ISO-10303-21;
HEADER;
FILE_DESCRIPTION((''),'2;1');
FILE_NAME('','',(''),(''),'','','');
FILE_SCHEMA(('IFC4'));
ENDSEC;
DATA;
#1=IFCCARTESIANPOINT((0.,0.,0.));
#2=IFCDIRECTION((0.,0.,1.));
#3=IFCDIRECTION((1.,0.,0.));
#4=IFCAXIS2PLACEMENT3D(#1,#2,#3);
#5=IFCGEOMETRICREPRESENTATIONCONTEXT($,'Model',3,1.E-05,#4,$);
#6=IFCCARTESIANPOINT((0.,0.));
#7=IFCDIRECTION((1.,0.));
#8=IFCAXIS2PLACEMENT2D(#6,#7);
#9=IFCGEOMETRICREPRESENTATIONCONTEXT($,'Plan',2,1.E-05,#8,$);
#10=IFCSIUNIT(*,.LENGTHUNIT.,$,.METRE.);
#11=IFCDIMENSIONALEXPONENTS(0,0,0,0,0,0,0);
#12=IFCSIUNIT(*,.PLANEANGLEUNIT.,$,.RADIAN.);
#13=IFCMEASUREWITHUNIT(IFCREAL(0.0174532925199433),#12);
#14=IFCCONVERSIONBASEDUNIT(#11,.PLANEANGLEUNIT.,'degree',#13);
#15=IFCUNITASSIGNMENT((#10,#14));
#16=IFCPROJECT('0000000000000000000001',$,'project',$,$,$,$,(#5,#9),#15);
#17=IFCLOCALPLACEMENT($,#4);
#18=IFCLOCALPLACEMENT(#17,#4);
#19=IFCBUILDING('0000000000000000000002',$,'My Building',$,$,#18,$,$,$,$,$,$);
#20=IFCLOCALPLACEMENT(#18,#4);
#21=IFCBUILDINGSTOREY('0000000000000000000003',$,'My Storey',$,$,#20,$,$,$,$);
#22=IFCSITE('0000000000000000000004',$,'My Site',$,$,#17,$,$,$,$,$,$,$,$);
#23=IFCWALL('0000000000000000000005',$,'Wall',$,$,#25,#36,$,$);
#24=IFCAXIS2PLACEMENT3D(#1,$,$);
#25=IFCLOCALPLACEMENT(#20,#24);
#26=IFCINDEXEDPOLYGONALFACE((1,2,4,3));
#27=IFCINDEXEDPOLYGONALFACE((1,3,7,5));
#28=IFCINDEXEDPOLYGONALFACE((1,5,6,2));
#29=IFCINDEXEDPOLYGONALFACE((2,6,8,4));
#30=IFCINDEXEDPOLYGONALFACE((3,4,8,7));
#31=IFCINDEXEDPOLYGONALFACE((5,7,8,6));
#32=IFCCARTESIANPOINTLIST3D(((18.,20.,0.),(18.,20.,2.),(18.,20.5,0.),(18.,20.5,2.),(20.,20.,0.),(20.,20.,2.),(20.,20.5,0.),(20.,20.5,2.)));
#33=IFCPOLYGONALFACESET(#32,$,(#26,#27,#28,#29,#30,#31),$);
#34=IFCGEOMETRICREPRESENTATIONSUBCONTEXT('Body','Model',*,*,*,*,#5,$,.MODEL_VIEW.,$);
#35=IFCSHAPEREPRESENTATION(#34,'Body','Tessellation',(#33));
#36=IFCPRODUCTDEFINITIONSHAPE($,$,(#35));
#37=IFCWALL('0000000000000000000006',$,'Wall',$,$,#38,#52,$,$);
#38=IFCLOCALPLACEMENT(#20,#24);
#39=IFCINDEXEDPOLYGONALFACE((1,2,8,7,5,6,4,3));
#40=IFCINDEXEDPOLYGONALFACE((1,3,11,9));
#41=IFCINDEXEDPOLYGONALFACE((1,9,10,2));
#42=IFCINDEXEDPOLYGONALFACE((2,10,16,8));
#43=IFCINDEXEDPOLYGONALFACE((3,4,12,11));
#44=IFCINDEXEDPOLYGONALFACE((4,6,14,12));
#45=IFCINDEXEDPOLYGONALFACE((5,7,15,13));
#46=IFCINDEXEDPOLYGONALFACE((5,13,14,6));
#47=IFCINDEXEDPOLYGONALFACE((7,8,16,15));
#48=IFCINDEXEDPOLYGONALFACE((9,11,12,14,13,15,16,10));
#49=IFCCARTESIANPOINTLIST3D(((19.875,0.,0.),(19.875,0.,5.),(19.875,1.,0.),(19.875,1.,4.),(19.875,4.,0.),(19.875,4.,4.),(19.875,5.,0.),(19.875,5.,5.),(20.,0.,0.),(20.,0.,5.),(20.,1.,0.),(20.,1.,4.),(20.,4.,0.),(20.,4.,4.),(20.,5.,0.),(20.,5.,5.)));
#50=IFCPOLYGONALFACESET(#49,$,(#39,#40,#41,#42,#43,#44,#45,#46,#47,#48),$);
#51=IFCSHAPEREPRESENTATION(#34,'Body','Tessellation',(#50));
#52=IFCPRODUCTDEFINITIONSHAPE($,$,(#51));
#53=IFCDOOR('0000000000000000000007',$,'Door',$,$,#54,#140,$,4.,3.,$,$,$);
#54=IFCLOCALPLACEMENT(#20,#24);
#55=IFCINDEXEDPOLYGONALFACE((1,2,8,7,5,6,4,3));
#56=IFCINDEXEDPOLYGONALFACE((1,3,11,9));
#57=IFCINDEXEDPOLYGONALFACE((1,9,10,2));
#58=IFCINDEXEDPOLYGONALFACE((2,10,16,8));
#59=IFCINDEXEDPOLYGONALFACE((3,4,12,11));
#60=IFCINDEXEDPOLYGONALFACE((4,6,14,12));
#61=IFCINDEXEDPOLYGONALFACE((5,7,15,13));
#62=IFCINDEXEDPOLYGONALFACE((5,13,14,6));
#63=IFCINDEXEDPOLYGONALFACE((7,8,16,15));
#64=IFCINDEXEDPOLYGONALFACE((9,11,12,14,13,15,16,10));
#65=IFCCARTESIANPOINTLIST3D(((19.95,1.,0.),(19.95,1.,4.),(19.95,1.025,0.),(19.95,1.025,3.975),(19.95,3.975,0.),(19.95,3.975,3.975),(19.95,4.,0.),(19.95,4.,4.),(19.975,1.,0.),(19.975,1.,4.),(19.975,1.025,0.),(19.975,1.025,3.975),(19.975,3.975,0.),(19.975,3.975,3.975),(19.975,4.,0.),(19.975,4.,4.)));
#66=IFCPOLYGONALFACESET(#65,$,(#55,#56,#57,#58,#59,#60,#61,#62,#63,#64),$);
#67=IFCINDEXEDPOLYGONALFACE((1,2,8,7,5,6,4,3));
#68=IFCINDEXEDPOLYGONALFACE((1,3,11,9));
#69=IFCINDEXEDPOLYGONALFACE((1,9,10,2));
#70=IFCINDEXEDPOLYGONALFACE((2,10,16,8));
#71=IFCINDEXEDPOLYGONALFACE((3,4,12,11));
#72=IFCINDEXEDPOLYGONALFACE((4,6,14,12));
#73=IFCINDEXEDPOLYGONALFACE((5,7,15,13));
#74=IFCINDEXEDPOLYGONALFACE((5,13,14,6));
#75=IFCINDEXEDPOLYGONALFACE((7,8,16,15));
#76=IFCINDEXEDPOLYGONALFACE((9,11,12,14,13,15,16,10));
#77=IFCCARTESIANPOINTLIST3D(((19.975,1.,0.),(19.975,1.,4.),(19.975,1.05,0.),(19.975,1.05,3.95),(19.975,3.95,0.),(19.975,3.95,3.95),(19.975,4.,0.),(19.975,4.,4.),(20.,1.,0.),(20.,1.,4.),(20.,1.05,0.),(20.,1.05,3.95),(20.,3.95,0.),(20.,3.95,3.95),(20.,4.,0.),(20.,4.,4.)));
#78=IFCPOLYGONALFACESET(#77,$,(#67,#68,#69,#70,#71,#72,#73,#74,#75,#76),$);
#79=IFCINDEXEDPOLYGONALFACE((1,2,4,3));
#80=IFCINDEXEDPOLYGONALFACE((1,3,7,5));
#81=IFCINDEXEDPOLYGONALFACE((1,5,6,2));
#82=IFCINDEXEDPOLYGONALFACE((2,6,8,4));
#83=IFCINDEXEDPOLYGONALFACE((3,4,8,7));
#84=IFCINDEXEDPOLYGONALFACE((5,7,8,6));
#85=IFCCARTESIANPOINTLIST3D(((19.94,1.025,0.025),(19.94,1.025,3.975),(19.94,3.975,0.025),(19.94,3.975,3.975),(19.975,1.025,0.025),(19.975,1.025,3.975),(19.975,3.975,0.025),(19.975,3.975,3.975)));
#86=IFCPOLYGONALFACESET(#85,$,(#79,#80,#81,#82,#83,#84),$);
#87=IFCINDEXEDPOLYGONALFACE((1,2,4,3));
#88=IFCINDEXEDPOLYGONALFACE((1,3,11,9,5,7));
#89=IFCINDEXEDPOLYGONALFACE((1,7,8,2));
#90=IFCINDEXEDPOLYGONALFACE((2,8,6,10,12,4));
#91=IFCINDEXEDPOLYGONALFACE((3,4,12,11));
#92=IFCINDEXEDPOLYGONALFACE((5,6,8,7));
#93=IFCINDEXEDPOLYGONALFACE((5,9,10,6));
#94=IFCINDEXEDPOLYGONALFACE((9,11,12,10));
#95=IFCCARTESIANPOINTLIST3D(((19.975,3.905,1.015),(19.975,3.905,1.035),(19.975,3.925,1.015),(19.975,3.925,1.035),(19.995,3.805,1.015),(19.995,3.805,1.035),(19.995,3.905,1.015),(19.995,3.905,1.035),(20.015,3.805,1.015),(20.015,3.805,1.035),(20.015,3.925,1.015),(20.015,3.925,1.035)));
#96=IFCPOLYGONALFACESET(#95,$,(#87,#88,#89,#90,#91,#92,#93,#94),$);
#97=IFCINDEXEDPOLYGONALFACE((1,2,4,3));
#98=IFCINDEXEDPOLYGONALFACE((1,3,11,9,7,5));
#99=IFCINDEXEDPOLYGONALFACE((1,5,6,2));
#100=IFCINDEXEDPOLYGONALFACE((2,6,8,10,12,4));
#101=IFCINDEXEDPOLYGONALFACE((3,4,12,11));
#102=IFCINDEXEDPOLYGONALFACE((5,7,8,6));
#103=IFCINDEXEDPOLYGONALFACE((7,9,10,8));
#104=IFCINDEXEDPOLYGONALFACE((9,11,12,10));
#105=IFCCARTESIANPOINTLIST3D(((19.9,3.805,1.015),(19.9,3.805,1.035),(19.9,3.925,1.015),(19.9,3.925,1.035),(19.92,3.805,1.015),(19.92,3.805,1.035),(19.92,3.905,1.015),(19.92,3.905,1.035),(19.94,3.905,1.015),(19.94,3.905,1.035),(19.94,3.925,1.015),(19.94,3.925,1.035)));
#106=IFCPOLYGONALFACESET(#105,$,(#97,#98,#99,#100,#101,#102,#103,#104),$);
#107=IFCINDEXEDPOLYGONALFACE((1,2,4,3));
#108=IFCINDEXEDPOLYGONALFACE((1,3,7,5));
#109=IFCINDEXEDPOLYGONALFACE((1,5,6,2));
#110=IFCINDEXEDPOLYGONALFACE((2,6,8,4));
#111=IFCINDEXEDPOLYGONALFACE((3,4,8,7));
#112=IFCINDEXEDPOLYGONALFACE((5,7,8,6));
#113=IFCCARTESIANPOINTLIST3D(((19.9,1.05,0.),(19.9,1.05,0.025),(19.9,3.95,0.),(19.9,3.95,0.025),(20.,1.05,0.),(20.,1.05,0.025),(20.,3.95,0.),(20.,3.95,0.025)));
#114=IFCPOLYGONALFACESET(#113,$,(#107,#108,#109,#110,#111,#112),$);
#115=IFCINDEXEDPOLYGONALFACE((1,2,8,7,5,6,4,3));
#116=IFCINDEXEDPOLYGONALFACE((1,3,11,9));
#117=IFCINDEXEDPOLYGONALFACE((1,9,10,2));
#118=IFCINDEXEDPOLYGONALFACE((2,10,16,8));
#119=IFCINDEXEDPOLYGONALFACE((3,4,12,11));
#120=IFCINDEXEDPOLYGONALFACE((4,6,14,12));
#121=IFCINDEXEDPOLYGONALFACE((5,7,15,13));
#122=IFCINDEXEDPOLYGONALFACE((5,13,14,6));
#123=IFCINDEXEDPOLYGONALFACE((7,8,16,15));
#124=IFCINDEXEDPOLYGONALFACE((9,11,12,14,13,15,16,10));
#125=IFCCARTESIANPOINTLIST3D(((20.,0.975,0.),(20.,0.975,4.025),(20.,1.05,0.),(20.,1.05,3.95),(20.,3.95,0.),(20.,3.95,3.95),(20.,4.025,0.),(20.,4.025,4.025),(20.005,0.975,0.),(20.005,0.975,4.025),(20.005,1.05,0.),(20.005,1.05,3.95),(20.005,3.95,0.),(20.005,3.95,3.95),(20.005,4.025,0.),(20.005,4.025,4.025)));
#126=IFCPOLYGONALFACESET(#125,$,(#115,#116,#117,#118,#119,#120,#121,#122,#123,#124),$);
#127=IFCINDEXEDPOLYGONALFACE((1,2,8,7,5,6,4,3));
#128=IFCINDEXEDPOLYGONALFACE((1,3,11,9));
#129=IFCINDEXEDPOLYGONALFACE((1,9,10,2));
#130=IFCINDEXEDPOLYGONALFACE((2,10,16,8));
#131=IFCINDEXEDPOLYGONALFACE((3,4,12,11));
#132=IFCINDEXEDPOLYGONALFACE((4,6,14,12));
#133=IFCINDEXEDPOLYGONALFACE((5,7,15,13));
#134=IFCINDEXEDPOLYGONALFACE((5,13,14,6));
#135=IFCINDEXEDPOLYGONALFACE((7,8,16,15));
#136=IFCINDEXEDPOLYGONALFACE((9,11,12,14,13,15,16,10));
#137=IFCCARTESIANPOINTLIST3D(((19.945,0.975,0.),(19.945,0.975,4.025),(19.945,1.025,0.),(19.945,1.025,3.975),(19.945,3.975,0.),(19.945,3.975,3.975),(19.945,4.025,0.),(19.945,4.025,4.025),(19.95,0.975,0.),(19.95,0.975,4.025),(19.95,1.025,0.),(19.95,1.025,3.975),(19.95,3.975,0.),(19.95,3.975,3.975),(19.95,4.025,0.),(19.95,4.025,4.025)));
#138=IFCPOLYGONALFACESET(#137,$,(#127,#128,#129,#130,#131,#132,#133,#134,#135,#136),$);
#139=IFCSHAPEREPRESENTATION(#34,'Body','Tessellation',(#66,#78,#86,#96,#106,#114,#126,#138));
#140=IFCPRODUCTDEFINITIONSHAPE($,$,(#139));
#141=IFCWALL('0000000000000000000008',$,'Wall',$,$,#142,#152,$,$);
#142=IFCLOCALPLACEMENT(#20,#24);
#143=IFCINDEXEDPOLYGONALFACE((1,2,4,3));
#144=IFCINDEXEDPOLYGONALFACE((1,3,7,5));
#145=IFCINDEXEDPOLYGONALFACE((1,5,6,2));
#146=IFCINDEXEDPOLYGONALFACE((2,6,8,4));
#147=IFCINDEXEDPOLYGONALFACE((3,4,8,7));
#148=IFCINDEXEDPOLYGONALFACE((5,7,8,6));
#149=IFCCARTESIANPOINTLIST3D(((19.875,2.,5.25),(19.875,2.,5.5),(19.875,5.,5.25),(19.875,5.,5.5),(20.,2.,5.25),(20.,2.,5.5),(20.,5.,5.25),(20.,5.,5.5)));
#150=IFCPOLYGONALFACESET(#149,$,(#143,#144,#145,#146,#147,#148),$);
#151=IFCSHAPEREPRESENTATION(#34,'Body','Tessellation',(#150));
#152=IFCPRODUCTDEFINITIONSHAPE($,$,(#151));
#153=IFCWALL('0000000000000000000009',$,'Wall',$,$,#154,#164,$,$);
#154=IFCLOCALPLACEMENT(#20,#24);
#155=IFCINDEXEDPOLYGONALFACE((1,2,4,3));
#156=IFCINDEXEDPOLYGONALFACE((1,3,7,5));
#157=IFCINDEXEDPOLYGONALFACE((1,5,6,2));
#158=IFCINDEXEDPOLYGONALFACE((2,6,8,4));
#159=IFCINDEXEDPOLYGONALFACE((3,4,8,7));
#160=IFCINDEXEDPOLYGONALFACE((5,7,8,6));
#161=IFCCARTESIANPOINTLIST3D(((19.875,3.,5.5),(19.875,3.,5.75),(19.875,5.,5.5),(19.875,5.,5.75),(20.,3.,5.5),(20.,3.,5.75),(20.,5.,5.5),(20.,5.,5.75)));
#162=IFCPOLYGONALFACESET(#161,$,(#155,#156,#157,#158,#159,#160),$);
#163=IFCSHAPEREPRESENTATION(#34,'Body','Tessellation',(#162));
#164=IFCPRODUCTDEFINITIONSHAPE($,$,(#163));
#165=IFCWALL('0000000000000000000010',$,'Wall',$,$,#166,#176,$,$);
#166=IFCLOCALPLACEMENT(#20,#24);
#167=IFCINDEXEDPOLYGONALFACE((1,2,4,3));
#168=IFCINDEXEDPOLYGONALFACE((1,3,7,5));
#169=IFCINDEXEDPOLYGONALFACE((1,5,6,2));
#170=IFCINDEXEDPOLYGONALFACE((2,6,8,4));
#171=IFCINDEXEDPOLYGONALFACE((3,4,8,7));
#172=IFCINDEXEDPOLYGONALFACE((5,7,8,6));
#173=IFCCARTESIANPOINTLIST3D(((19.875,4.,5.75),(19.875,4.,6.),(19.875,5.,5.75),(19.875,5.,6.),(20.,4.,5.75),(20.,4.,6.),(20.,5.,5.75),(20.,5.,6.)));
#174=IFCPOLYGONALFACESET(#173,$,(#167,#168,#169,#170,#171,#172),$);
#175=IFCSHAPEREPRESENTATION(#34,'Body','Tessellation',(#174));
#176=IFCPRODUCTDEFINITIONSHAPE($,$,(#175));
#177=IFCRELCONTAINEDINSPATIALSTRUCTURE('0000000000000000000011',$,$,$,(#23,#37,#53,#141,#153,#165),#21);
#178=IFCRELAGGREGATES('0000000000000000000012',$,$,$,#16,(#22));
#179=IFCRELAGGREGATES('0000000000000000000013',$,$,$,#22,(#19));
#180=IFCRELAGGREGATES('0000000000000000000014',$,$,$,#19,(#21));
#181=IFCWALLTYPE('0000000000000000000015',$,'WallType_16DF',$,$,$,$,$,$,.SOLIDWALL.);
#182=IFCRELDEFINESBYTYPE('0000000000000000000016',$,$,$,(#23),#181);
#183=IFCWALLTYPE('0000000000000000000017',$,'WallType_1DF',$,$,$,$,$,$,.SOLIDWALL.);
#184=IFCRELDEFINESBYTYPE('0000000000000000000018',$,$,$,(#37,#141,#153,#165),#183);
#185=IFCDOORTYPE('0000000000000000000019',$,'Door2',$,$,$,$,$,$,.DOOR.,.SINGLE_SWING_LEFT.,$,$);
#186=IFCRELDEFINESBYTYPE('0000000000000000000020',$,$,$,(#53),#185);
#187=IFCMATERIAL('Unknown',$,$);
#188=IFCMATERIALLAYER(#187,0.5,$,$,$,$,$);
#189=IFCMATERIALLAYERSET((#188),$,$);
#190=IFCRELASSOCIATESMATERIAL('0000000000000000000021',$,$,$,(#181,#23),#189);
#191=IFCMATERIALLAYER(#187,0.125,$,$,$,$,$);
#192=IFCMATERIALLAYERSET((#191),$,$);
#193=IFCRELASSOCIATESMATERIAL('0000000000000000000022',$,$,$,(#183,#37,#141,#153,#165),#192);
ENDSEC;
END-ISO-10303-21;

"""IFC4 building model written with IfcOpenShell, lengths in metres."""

from ifc_helpers import new_model, entity, si_unit, converted_unit, frame, origin_with_axes, origin_2d_with_axis, place, context, subcontext, project, spatial, line, indexed_curve, outline, extrude, shape, source, transform, mapped, material, layer, layer_set, layer_usage, type_object, type_shapes, element, fill, save


model = new_model("IFC4")

# Units and contexts
model_context = context("Model", 3, precision=1e-05, world=origin_with_axes())
plan_context = context("Plan", 2, precision=1e-05, world=origin_2d_with_axis())
body_context_1 = subcontext(model_context, "Body", "Model", "MODEL_VIEW")
body_context_2 = subcontext(plan_context, "Body", "Plan", "PLAN_VIEW")
ifc_project = project(units=[si_unit("LENGTHUNIT", "METRE"), converted_unit("PLANEANGLEUNIT", "degree", entity("IfcReal", 0.0174532925199433), si_unit("PLANEANGLEUNIT", "RADIAN"), dimensions=[0, 0, 0, 0, 0, 0, 0])], contexts=[model_context, plan_context])

# Site, building, storey
site_placement = place(None, origin_with_axes())
site = spatial("IfcSite", under=ifc_project, at=site_placement, Name="My Site")
building_placement = place(site_placement, origin_with_axes())
building = spatial("IfcBuilding", under=site, at=building_placement, Name="My Building")
storey_placement = place(building_placement, origin_with_axes())
storey = spatial("IfcBuildingStorey", under=building, at=storey_placement, Name="My Storey")

# Wall
ifc_material = material(Name="Unknown")
ifc_layer_1 = layer(ifc_material, 0.5)
ifc_layer_set_1 = layer_set([ifc_layer_1])
ifc_layer_usage_1 = layer_usage(ifc_layer_set_1, "AXIS2", "POSITIVE", 0.0)
wall_type_1 = type_object("IfcWallType", Name="WallType_16DF", PredefinedType="SOLIDWALL", material=ifc_layer_set_1)
wall_1_placement = place(storey_placement, frame((18.0, 20.0, 0.0), z_axis=(0.0, 0.0, 1.0), x_axis=(1.0, 0.0, 0.0)))
element("IfcWall", 1, at=wall_1_placement, inside=storey, type_object=wall_type_1, material=ifc_layer_usage_1, Name="Wall", context=body_context_1, shape_type="SweptSolid", body=[
    extrude(outline(indexed_curve([(0.0, 0.0), (0.0, 0.5), (2.0, 0.5), (2.0, 0.0), (0.0, 0.0)], self_intersect=False)), origin_with_axes(), (0.0, 0.0, 1.0), 2.0),
])

# Wall, opening, door
ifc_layer_2 = layer(ifc_material, 0.125)
ifc_layer_set_2 = layer_set([ifc_layer_2])
ifc_layer_usage_2 = layer_usage(ifc_layer_set_2, "AXIS2", "POSITIVE", 0.0)
wall_type_2 = type_object("IfcWallType", Name="WallType_1DF", PredefinedType="SOLIDWALL", material=ifc_layer_set_2)
wall_2_placement = place(storey_placement, frame((20.0, 0.0, 0.0), z_axis=(0.0, 0.0, 1.0), x_axis=(0.0, 1.0, 0.0)))
wall_2 = element("IfcWall", 2, at=wall_2_placement, inside=storey, type_object=wall_type_2, material=ifc_layer_usage_2, Name="Wall", context=body_context_1, shape_type="SweptSolid", body=[
    extrude(outline(indexed_curve([(0.0, 0.0), (0.0, 0.125), (5.0, 0.125), (5.0, 0.0), (0.0, 0.0)], self_intersect=False)), origin_with_axes(), (0.0, 0.0, 1.0), 5.0),
])
shared_shape_1 = source(origin_with_axes(), body_context_1, "Body", "SweptSolid", [
    extrude(outline(indexed_curve([(0.0, 0.0), (3.0, 0.0), (3.0, 4.0), (0.0, 4.0)], segments=[line(1, 2, 3, 4, 1)])), frame((0.0, -0.1, 0.0), z_axis=(0.0, -1.0, 0.0), x_axis=(1.0, 0.0, 0.0)), (0.0, 0.0, -1.0), 0.45),
])
opening_1_placement = place(wall_2_placement, frame((1.0, 0.0, 0.0), z_axis=(0.0, 0.0, 1.0), x_axis=(1.0, 0.0, 0.0)))
opening_1 = element("IfcOpeningElement", 3, at=opening_1_placement, cuts=wall_2, PredefinedType="OPENING", context=body_context_1, shape_type="MappedRepresentation", body=[
    mapped(shared_shape_1, transform((0.0, 0.0, 0.0), x_axis=(1.0, 0.0, 0.0), y_axis=(0.0, 1.0, 0.0), z_axis=(0.0, 0.0, 1.0), scale=1.0)),
])
door_type_1 = type_object("IfcDoorType", Name="Door2", OperationType="SINGLE_SWING_LEFT", PredefinedType="DOOR")
shared_shape_2 = source(origin_with_axes(), body_context_1, "Body", "SweptSolid", [
    extrude(outline(indexed_curve([(0.0, 0.0), (0.0, 4.0), (3.0, 4.0), (3.0, 0.0), (2.975, 0.0), (2.975, 3.975), (0.025, 3.975), (0.025, 0.0)], segments=[line(1, 2, 3, 4, 5, 6, 7, 8, 1)])), frame((0.0, 0.025, 0.0), z_axis=(0.0, -1.0, 0.0), x_axis=(1.0, 0.0, 0.0)), (0.0, 0.0, -1.0), 0.025),
    extrude(outline(indexed_curve([(0.0, 0.0), (0.0, 4.0), (3.0, 4.0), (3.0, 0.0), (2.95, 0.0), (2.95, 3.95), (0.05, 3.95), (0.05, 0.0)], segments=[line(1, 2, 3, 4, 5, 6, 7, 8, 1)])), frame((0.0, 0.0, 0.0), z_axis=(0.0, -1.0, 0.0), x_axis=(1.0, 0.0, 0.0)), (0.0, 0.0, -1.0), 0.025),
    extrude(outline(indexed_curve([(0.0, 0.0), (2.95, 0.0), (2.95, 0.035), (0.0, 0.035)], segments=[line(1, 2, 3, 4, 1)])), frame((0.025, 0.025, 0.025), z_axis=(0.0, 0.0, 1.0), x_axis=(1.0, 0.0, 0.0)), (0.0, 0.0, 1.0), 3.95),
    extrude(outline(indexed_curve([(0.0, 0.0), (0.0, -0.04), (-0.12, -0.04), (-0.12, -0.02), (-0.02, -0.02), (-0.02, 0.0)], segments=[line(1, 2, 3, 4, 5, 6, 1)])), frame((2.925, 0.025, 1.015), z_axis=(0.0, 0.0, 1.0), x_axis=(1.0, 0.0, 0.0)), (0.0, 0.0, 1.0), 0.02),
    extrude(outline(indexed_curve([(0.0, 0.0), (0.0, 0.04), (-0.12, 0.04), (-0.12, 0.02), (-0.02, 0.02), (-0.02, 0.0)], segments=[line(1, 2, 3, 4, 5, 6, 1)])), frame((2.925, 0.06, 1.015), z_axis=(0.0, 0.0, 1.0), x_axis=(1.0, 0.0, 0.0)), (0.0, 0.0, 1.0), 0.02),
    extrude(outline(indexed_curve([(0.0, 0.0), (2.9, 0.0), (2.9, 0.1), (0.0, 0.1)], segments=[line(1, 2, 3, 4, 1)])), frame((0.05, 0.0, 0.0), z_axis=(0.0, 0.0, 1.0), x_axis=(1.0, 0.0, 0.0)), (0.0, 0.0, 1.0), 0.025),
    extrude(outline(indexed_curve([(0.0, 0.0), (0.0, 4.025), (3.05, 4.025), (3.05, 0.0), (2.975, 0.0), (2.975, 3.95), (0.075, 3.95), (0.075, 0.0)], segments=[line(1, 2, 3, 4, 5, 6, 7, 8, 1)])), frame((-0.025, -0.005, 0.0), z_axis=(0.0, -1.0, 0.0), x_axis=(1.0, 0.0, 0.0)), (0.0, 0.0, -1.0), 0.005),
    extrude(outline(indexed_curve([(0.0, 0.0), (0.0, 4.025), (3.05, 4.025), (3.05, 0.0), (3.0, 0.0), (3.0, 3.975), (0.05, 3.975), (0.05, 0.0)], segments=[line(1, 2, 3, 4, 5, 6, 7, 8, 1)])), frame((-0.025, 0.05, 0.0), z_axis=(0.0, -1.0, 0.0), x_axis=(1.0, 0.0, 0.0)), (0.0, 0.0, -1.0), 0.005),
])
shared_shape_3 = source(origin_with_axes(), body_context_2, "Body", "Curve2D", [
    entity("IfcIndexedPolyCurve", entity("IfcCartesianPointList2D", [[0.0, 0.0], [0.0, 0.05], [0.025, 0.05], [0.025, 0.025], [0.05, 0.025], [0.05, 0.0]]), [entity("IfcLineIndex", [1, 2, 3, 4, 5, 6, 1])]),
    entity("IfcIndexedPolyCurve", entity("IfcCartesianPointList2D", [[3.0, 0.0], [3.0, 0.05], [2.975, 0.05], [2.975, 0.025], [2.95, 0.025], [2.95, 0.0]]), [entity("IfcLineIndex", [1, 2, 3, 4, 5, 6, 1])]),
    entity("IfcTrimmedCurve", entity("IfcEllipse", entity("IfcAxis2Placement2D", entity("IfcCartesianPoint", [0.06, 0.05]), entity("IfcDirection", [1.0, 0.0])), 2.915, 2.95), [entity("IfcCartesianPoint", [2.975, 0.05])], [entity("IfcCartesianPoint", [0.06, 3.0])], True, "CARTESIAN"),
    entity("IfcIndexedPolyCurve", entity("IfcCartesianPointList2D", [[0.025, 0.05], [0.06, 0.05], [0.06, 3.0], [0.025, 3.0]]), [entity("IfcLineIndex", [1, 2, 3, 4, 1])]),
])
type_shapes(door_type_1, [shared_shape_2, shared_shape_3])
door_1_placement = place(opening_1_placement, frame((0.0, 0.0, 0.0), z_axis=(0.0, 0.0, 1.0), x_axis=(1.0, 0.0, 0.0)))
door_1 = element("IfcDoor", 4, at=door_1_placement, inside=storey, type_object=door_type_1, Name="Door", OverallHeight=4.0, OverallWidth=3.0, shapes=[
    shape(body_context_1, "Body", "MappedRepresentation", [mapped(shared_shape_2, transform((0.0, 0.0, 0.0), x_axis=(1.0, 0.0, 0.0), y_axis=(0.0, 1.0, 0.0), z_axis=(0.0, 0.0, 1.0), scale=1.0))]),
    shape(body_context_2, "Body", "MappedRepresentation", [mapped(shared_shape_3, transform((0.0, 0.0, 0.0), x_axis=(1.0, 0.0, 0.0), y_axis=(0.0, 1.0, 0.0), z_axis=(0.0, 0.0, 1.0), scale=1.0))]),
])
fill(opening_1, door_1)

# Walls
ifc_layer_usage_3 = layer_usage(ifc_layer_set_2, "AXIS2", "POSITIVE", 0.0)
wall_3_placement = place(storey_placement, frame((20.0, 2.0, 5.25), z_axis=(0.0, 0.0, 1.0), x_axis=(0.0, 1.0, 0.0)))
element("IfcWall", 5, at=wall_3_placement, inside=storey, type_object=wall_type_2, material=ifc_layer_usage_3, Name="Wall", context=body_context_1, shape_type="SweptSolid", body=[
    extrude(outline(indexed_curve([(0.0, 0.0), (0.0, 0.125), (3.0, 0.125), (3.0, 0.0), (0.0, 0.0)], self_intersect=False)), origin_with_axes(), (0.0, 0.0, 1.0), 0.25),
])
ifc_layer_usage_4 = layer_usage(ifc_layer_set_2, "AXIS2", "POSITIVE", 0.0)
wall_4_placement = place(storey_placement, frame((20.0, 3.0, 5.5), z_axis=(0.0, 0.0, 1.0), x_axis=(0.0, 1.0, 0.0)))
element("IfcWall", 6, at=wall_4_placement, inside=storey, type_object=wall_type_2, material=ifc_layer_usage_4, Name="Wall", context=body_context_1, shape_type="SweptSolid", body=[
    extrude(outline(indexed_curve([(0.0, 0.0), (0.0, 0.125), (2.0, 0.125), (2.0, 0.0), (0.0, 0.0)], self_intersect=False)), origin_with_axes(), (0.0, 0.0, 1.0), 0.25),
])
ifc_layer_usage_5 = layer_usage(ifc_layer_set_2, "AXIS2", "POSITIVE", 0.0)
wall_5_placement = place(storey_placement, frame((20.0, 4.0, 5.75), z_axis=(0.0, 0.0, 1.0), x_axis=(0.0, 1.0, 0.0)))
element("IfcWall", 7, at=wall_5_placement, inside=storey, type_object=wall_type_2, material=ifc_layer_usage_5, Name="Wall", context=body_context_1, shape_type="SweptSolid", body=[
    extrude(outline(indexed_curve([(0.0, 0.0), (0.0, 0.125), (1.0, 0.125), (1.0, 0.0), (0.0, 0.0)], self_intersect=False)), origin_with_axes(), (0.0, 0.0, 1.0), 0.25),
])

save(model, "model.ifc")
